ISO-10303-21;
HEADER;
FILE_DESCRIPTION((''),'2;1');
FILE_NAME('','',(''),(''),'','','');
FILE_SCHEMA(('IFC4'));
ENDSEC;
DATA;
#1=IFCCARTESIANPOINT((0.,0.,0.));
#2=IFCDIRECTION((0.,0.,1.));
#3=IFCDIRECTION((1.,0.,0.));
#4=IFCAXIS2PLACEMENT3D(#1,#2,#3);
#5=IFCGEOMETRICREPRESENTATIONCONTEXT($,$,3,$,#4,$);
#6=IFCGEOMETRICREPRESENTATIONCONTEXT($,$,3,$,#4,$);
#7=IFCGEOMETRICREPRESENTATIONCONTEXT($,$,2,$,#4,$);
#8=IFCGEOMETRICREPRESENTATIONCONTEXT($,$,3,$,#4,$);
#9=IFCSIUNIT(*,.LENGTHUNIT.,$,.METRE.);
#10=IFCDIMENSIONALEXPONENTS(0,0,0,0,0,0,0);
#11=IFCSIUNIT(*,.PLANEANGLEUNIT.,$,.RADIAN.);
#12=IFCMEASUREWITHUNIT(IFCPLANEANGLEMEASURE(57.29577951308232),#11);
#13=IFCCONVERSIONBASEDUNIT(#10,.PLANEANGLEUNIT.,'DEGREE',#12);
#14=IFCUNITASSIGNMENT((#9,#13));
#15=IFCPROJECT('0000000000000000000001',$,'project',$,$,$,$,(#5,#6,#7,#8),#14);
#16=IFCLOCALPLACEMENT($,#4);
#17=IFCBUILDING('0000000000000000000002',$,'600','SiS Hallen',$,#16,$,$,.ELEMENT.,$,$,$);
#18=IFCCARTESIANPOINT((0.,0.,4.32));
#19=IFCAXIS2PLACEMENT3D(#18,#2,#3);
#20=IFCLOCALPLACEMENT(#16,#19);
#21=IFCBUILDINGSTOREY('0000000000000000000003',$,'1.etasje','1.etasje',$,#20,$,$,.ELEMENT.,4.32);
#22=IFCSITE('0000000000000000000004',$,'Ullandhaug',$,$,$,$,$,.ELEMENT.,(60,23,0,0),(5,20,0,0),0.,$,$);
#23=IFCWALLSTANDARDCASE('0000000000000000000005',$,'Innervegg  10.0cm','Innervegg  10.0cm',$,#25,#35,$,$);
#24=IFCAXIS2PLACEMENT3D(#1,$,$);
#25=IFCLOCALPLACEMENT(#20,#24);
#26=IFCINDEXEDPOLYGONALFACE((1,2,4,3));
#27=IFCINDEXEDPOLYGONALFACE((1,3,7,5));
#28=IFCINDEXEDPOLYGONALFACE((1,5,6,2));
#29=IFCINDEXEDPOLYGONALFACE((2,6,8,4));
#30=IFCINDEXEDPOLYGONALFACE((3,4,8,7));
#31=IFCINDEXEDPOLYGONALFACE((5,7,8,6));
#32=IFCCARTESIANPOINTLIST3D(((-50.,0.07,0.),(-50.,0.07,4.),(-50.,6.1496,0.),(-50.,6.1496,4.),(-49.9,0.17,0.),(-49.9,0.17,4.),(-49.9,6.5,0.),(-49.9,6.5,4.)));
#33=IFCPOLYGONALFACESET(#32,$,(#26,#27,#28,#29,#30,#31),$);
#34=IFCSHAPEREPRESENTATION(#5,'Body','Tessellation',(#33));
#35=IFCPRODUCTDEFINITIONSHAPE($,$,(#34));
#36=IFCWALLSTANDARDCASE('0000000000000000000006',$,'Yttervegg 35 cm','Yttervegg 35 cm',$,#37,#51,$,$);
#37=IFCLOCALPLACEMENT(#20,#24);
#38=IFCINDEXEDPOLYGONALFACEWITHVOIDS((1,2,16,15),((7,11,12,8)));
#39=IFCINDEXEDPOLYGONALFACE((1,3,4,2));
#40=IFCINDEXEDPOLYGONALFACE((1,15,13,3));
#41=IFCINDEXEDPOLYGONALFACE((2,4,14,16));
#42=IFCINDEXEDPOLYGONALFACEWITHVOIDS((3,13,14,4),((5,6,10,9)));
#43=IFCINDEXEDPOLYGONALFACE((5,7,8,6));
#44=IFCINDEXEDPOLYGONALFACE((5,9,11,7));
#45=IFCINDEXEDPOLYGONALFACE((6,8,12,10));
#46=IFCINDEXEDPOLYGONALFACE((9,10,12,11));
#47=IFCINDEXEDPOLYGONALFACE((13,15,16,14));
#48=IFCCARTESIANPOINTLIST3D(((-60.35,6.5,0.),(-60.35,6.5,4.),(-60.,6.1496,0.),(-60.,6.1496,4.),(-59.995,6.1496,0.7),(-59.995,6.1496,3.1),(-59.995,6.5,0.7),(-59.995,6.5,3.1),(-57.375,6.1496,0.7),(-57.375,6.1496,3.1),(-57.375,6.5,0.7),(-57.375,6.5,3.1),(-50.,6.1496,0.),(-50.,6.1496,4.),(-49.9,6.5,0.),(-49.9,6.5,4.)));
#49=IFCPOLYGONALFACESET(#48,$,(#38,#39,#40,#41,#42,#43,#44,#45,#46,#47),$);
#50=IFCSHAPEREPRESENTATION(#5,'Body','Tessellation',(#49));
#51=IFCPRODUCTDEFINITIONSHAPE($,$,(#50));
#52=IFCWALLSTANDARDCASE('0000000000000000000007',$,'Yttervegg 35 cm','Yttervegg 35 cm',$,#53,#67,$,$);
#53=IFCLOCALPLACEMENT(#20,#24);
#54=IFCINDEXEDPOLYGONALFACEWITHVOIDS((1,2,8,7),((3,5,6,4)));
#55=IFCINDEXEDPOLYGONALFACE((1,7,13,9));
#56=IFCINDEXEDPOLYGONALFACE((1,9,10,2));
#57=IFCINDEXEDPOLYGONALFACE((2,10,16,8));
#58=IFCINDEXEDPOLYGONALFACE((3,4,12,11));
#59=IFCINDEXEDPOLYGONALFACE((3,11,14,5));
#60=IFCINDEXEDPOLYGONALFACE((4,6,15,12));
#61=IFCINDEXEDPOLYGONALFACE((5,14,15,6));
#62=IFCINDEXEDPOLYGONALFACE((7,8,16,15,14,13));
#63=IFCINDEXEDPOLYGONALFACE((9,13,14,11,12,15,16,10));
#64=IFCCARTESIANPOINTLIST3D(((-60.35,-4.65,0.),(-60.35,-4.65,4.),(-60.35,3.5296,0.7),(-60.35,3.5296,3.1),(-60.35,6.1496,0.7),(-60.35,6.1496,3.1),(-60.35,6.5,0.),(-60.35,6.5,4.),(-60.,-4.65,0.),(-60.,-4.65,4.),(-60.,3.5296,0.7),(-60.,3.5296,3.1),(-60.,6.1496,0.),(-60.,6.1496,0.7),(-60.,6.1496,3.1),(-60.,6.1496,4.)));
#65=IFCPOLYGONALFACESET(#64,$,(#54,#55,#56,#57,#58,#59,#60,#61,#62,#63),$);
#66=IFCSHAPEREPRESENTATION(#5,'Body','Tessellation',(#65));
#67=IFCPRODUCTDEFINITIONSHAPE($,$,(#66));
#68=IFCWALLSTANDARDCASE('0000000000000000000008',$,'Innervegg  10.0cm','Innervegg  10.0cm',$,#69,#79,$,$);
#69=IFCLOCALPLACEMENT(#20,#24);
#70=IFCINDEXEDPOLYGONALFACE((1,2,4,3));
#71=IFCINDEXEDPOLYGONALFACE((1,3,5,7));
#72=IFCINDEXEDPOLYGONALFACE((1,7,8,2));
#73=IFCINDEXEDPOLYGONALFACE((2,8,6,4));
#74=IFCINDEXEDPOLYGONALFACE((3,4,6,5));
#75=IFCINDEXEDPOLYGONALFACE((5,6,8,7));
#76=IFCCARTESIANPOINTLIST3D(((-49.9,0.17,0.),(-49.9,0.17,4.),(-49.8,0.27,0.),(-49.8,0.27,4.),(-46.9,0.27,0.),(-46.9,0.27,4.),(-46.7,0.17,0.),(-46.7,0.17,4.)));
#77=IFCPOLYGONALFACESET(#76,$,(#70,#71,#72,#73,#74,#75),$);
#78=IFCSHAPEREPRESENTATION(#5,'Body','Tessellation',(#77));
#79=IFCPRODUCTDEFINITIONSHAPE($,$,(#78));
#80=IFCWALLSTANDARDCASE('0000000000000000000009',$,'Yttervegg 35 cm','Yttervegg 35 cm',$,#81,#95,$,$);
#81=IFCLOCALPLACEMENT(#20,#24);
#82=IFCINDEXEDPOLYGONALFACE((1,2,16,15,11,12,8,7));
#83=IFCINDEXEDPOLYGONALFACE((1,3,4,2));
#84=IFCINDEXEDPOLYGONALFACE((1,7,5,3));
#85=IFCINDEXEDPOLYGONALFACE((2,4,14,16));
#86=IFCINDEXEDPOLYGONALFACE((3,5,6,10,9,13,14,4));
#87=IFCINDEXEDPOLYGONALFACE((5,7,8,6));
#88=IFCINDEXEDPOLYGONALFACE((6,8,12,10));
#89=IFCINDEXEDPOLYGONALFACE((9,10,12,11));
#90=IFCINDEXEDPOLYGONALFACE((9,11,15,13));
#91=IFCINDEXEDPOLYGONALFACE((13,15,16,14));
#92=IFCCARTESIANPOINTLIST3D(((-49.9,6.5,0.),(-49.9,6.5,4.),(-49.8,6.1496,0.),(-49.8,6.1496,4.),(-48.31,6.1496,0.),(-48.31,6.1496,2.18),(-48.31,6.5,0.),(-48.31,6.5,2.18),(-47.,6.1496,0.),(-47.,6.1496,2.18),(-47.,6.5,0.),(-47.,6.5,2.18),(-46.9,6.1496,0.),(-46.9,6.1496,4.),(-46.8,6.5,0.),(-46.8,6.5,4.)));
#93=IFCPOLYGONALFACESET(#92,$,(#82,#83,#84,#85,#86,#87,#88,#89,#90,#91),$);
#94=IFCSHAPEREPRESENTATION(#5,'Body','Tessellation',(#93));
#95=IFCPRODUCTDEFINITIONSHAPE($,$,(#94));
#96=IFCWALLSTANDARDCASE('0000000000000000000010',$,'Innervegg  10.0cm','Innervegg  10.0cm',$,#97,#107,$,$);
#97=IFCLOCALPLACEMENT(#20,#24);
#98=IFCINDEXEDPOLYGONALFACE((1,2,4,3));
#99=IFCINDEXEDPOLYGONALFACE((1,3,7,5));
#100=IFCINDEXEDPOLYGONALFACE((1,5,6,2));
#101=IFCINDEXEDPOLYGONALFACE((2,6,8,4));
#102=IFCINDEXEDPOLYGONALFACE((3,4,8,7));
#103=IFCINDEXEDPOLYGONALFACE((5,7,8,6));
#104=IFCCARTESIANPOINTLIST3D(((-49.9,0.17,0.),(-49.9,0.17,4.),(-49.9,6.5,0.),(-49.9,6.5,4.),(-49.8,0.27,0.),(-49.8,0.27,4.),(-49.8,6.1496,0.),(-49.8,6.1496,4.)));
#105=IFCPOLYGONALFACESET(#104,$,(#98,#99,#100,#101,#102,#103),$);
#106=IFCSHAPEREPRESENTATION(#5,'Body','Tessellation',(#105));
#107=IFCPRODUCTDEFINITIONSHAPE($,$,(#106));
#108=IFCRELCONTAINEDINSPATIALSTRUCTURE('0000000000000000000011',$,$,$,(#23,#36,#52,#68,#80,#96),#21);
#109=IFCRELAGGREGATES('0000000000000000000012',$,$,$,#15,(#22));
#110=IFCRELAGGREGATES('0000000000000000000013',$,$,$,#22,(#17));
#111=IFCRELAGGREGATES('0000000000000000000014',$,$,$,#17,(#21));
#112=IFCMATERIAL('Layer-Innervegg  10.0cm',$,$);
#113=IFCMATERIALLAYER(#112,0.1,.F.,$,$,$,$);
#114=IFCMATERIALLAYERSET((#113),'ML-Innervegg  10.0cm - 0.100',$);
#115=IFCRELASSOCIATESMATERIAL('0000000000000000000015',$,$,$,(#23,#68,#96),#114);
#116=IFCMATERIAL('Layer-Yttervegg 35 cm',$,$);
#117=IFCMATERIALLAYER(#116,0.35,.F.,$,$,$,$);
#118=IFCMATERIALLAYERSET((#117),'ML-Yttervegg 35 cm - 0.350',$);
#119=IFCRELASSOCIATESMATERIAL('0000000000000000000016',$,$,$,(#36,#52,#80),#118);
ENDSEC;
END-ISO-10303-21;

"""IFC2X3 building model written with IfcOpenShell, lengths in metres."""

from ifc_helpers import new_model, entity, si_unit, converted_unit, frame, origin_with_axes, place, context, project, spatial, polyline, outline, extrude, material, layer, layer_set, layer_usage, element, save


model = new_model("IFC2X3")

# Units and contexts
context_of_model_1 = context(None, 3, world=origin_with_axes())
context_of_model_2 = context(None, 3, world=origin_with_axes())
context_of_model_3 = context(None, 2, world=origin_with_axes())
context_of_model_4 = context(None, 3, world=origin_with_axes())
ifc_project = project(units=[si_unit("LENGTHUNIT", "METRE"), converted_unit("PLANEANGLEUNIT", "DEGREE", entity("IfcPlaneAngleMeasure", 57.29577951308232), si_unit("PLANEANGLEUNIT", "RADIAN"), dimensions=[0, 0, 0, 0, 0, 0, 0])], contexts=[context_of_model_1, context_of_model_2, context_of_model_3, context_of_model_4])

# Site, building, storey
site = spatial("IfcSite", under=ifc_project, Name="Ullandhaug", CompositionType="ELEMENT", RefLatitude=(60, 23, 0, 0), RefLongitude=(5, 20, 0, 0), RefElevation=0.0)
building_placement = place(None, origin_with_axes())
building = spatial("IfcBuilding", under=site, at=building_placement, Name="600", Description="SiS Hallen", CompositionType="ELEMENT")
storey_placement = place(building_placement, frame((0.0, 0.0, 4.32), z_axis=(0.0, 0.0, 1.0), x_axis=(1.0, 0.0, 0.0)))
storey = spatial("IfcBuildingStorey", under=building, at=storey_placement, Name="1.etasje", Description="1.etasje", CompositionType="ELEMENT", Elevation=4.32)

# Shared definitions
ifc_material_1 = material(Name="Layer-Yttervegg 35 cm")
ifc_layer_1 = layer(ifc_material_1, 0.35, ventilated=False)
ifc_layer_set_1 = layer_set([ifc_layer_1], Name="ML-Yttervegg 35 cm - 0.350")
ifc_layer_usage_1 = layer_usage(ifc_layer_set_1, "AXIS2", "POSITIVE", 0.0)
ifc_material_2 = material(Name="Layer-Innervegg  10.0cm")
ifc_layer_2 = layer(ifc_material_2, 0.1, ventilated=False)
ifc_layer_set_2 = layer_set([ifc_layer_2], Name="ML-Innervegg  10.0cm - 0.100")
ifc_layer_usage_2 = layer_usage(ifc_layer_set_2, "AXIS2", "POSITIVE", 0.0)

# Wall
wall_1_placement = place(storey_placement, frame((-49.9, 0.17, 0.0), z_axis=(0.0, 0.0, 1.0), x_axis=(0.0, 1.0, 0.0)))
element("IfcWallStandardCase", 1, at=wall_1_placement, inside=storey, material=ifc_layer_usage_2, Name="Innervegg  10.0cm", Description="Innervegg  10.0cm", context=context_of_model_1, shape_type="SweptSolid", body=[
    extrude(outline(polyline([(0.0, 0.0), (6.33, 0.0), (5.9796, 0.1), (-0.1, 0.1), (0.0, 0.0)])), frame((0.0, 0.0, 0.0), z_axis=(0.0, 0.0, 1.0), x_axis=(1.0, 0.0, 0.0)), (0.0, 0.0, 1.0), 4.0),
])

# Walls, openings
wall_2_placement = place(storey_placement, frame((-49.9, 6.5, 0.0), z_axis=(0.0, 0.0, 1.0), x_axis=(-1.0, 0.0, 0.0)))
wall_2 = element("IfcWallStandardCase", 2, at=wall_2_placement, inside=storey, material=ifc_layer_usage_1, Name="Yttervegg 35 cm", Description="Yttervegg 35 cm", context=context_of_model_1, shape_type="SweptSolid", body=[
    extrude(outline(polyline([(0.0, 0.0), (10.45, 0.0), (10.1, 0.3504), (0.1, 0.3504), (0.0, 0.0)])), frame((0.0, 0.0, 0.0), z_axis=(0.0, 0.0, 1.0), x_axis=(1.0, 0.0, 0.0)), (0.0, 0.0, 1.0), 4.0),
])
opening_1_placement = place(wall_2_placement, frame((7.475, 0.3504, 0.7), z_axis=(0.0, 0.0, 1.0), x_axis=(1.0, 0.0, 0.0)))
element("IfcOpeningElement", 3, at=opening_1_placement, cuts=wall_2, context=context_of_model_1, shape_type="SweptSolid", body=[
    extrude(outline(polyline([(0.0, 0.0), (2.4, 0.0), (2.4, 2.62), (0.0, 2.62), (0.0, 0.0)])), frame((0.0, 0.0, 0.0), z_axis=(0.0, 1.0, 0.0), x_axis=(0.0, 0.0, 1.0)), (0.0, 0.0, -1.0), 0.3504),
])
wall_3_placement = place(storey_placement, frame((-60.35, 6.5, 0.0), z_axis=(0.0, 0.0, 1.0), x_axis=(0.0, -1.0, 0.0)))
wall_3 = element("IfcWallStandardCase", 4, at=wall_3_placement, inside=storey, material=ifc_layer_usage_1, Name="Yttervegg 35 cm", Description="Yttervegg 35 cm", context=context_of_model_1, shape_type="SweptSolid", body=[
    extrude(outline(polyline([(0.0, 0.0), (11.15, 0.0), (11.15, 0.35), (0.3504, 0.35), (0.0, 0.0)])), frame((0.0, 0.0, 0.0), z_axis=(0.0, 0.0, 1.0), x_axis=(1.0, 0.0, 0.0)), (0.0, 0.0, 1.0), 4.0),
])
opening_2_placement = place(wall_3_placement, frame((0.3504, 0.35, 0.7), z_axis=(0.0, 0.0, 1.0), x_axis=(1.0, 0.0, 0.0)))
element("IfcOpeningElement", 5, at=opening_2_placement, cuts=wall_3, context=context_of_model_1, shape_type="SweptSolid", body=[
    extrude(outline(polyline([(0.0, 0.0), (2.4, 0.0), (2.4, 2.62), (0.0, 2.62), (0.0, 0.0)])), frame((0.0, 0.0, 0.0), z_axis=(0.0, 1.0, 0.0), x_axis=(0.0, 0.0, 1.0)), (0.0, 0.0, -1.0), 0.35),
])

# Wall
wall_4_placement = place(storey_placement, frame((-49.9, 0.17, 0.0), z_axis=(0.0, 0.0, 1.0), x_axis=(1.0, 0.0, 0.0)))
element("IfcWallStandardCase", 6, at=wall_4_placement, inside=storey, material=ifc_layer_usage_2, Name="Innervegg  10.0cm", Description="Innervegg  10.0cm", context=context_of_model_1, shape_type="SweptSolid", body=[
    extrude(outline(polyline([(0.0, 0.0), (3.2, 0.0), (3.0, 0.1), (0.1, 0.1), (0.0, 0.0)])), origin_with_axes(), (0.0, 0.0, 1.0), 4.0),
])

# Wall, opening
wall_5_placement = place(storey_placement, frame((-46.8, 6.5, 0.0), z_axis=(0.0, 0.0, 1.0), x_axis=(-1.0, 0.0, 0.0)))
wall_5 = element("IfcWallStandardCase", 7, at=wall_5_placement, inside=storey, material=ifc_layer_usage_1, Name="Yttervegg 35 cm", Description="Yttervegg 35 cm", context=context_of_model_1, shape_type="SweptSolid", body=[
    extrude(outline(polyline([(0.0, 0.0), (3.1, 0.0), (3.0, 0.3504), (0.1, 0.3504), (0.0, 0.0)])), frame((0.0, 0.0, 0.0), z_axis=(0.0, 0.0, 1.0), x_axis=(1.0, 0.0, 0.0)), (0.0, 0.0, 1.0), 4.0),
])
opening_3_placement = place(wall_5_placement, frame((0.2, 0.3504, 0.0), z_axis=(0.0, 0.0, 1.0), x_axis=(1.0, 0.0, 0.0)))
element("IfcOpeningElement", 8, at=opening_3_placement, cuts=wall_5, context=context_of_model_1, shape_type="SweptSolid", body=[
    extrude(outline(polyline([(0.0, 0.0), (2.18, 0.0), (2.18, 1.31), (0.0, 1.31), (0.0, 0.0)])), frame((0.0, 0.0, 0.0), z_axis=(0.0, 1.0, 0.0), x_axis=(0.0, 0.0, 1.0)), (0.0, 0.0, -1.0), 0.3504),
])

# Wall
wall_6_placement = place(storey_placement, frame((-49.9, 6.5, 0.0), z_axis=(0.0, 0.0, 1.0), x_axis=(0.0, -1.0, 0.0)))
element("IfcWallStandardCase", 9, at=wall_6_placement, inside=storey, material=ifc_layer_usage_2, Name="Innervegg  10.0cm", Description="Innervegg  10.0cm", context=context_of_model_1, shape_type="SweptSolid", body=[
    extrude(outline(polyline([(0.0, 0.0), (6.33, 0.0), (6.23, 0.1), (0.3504, 0.1), (0.0, 0.0)])), frame((0.0, 0.0, 0.0), z_axis=(0.0, 0.0, 1.0), x_axis=(1.0, 0.0, 0.0)), (0.0, 0.0, 1.0), 4.0),
])

save(model, "model.ifc")
